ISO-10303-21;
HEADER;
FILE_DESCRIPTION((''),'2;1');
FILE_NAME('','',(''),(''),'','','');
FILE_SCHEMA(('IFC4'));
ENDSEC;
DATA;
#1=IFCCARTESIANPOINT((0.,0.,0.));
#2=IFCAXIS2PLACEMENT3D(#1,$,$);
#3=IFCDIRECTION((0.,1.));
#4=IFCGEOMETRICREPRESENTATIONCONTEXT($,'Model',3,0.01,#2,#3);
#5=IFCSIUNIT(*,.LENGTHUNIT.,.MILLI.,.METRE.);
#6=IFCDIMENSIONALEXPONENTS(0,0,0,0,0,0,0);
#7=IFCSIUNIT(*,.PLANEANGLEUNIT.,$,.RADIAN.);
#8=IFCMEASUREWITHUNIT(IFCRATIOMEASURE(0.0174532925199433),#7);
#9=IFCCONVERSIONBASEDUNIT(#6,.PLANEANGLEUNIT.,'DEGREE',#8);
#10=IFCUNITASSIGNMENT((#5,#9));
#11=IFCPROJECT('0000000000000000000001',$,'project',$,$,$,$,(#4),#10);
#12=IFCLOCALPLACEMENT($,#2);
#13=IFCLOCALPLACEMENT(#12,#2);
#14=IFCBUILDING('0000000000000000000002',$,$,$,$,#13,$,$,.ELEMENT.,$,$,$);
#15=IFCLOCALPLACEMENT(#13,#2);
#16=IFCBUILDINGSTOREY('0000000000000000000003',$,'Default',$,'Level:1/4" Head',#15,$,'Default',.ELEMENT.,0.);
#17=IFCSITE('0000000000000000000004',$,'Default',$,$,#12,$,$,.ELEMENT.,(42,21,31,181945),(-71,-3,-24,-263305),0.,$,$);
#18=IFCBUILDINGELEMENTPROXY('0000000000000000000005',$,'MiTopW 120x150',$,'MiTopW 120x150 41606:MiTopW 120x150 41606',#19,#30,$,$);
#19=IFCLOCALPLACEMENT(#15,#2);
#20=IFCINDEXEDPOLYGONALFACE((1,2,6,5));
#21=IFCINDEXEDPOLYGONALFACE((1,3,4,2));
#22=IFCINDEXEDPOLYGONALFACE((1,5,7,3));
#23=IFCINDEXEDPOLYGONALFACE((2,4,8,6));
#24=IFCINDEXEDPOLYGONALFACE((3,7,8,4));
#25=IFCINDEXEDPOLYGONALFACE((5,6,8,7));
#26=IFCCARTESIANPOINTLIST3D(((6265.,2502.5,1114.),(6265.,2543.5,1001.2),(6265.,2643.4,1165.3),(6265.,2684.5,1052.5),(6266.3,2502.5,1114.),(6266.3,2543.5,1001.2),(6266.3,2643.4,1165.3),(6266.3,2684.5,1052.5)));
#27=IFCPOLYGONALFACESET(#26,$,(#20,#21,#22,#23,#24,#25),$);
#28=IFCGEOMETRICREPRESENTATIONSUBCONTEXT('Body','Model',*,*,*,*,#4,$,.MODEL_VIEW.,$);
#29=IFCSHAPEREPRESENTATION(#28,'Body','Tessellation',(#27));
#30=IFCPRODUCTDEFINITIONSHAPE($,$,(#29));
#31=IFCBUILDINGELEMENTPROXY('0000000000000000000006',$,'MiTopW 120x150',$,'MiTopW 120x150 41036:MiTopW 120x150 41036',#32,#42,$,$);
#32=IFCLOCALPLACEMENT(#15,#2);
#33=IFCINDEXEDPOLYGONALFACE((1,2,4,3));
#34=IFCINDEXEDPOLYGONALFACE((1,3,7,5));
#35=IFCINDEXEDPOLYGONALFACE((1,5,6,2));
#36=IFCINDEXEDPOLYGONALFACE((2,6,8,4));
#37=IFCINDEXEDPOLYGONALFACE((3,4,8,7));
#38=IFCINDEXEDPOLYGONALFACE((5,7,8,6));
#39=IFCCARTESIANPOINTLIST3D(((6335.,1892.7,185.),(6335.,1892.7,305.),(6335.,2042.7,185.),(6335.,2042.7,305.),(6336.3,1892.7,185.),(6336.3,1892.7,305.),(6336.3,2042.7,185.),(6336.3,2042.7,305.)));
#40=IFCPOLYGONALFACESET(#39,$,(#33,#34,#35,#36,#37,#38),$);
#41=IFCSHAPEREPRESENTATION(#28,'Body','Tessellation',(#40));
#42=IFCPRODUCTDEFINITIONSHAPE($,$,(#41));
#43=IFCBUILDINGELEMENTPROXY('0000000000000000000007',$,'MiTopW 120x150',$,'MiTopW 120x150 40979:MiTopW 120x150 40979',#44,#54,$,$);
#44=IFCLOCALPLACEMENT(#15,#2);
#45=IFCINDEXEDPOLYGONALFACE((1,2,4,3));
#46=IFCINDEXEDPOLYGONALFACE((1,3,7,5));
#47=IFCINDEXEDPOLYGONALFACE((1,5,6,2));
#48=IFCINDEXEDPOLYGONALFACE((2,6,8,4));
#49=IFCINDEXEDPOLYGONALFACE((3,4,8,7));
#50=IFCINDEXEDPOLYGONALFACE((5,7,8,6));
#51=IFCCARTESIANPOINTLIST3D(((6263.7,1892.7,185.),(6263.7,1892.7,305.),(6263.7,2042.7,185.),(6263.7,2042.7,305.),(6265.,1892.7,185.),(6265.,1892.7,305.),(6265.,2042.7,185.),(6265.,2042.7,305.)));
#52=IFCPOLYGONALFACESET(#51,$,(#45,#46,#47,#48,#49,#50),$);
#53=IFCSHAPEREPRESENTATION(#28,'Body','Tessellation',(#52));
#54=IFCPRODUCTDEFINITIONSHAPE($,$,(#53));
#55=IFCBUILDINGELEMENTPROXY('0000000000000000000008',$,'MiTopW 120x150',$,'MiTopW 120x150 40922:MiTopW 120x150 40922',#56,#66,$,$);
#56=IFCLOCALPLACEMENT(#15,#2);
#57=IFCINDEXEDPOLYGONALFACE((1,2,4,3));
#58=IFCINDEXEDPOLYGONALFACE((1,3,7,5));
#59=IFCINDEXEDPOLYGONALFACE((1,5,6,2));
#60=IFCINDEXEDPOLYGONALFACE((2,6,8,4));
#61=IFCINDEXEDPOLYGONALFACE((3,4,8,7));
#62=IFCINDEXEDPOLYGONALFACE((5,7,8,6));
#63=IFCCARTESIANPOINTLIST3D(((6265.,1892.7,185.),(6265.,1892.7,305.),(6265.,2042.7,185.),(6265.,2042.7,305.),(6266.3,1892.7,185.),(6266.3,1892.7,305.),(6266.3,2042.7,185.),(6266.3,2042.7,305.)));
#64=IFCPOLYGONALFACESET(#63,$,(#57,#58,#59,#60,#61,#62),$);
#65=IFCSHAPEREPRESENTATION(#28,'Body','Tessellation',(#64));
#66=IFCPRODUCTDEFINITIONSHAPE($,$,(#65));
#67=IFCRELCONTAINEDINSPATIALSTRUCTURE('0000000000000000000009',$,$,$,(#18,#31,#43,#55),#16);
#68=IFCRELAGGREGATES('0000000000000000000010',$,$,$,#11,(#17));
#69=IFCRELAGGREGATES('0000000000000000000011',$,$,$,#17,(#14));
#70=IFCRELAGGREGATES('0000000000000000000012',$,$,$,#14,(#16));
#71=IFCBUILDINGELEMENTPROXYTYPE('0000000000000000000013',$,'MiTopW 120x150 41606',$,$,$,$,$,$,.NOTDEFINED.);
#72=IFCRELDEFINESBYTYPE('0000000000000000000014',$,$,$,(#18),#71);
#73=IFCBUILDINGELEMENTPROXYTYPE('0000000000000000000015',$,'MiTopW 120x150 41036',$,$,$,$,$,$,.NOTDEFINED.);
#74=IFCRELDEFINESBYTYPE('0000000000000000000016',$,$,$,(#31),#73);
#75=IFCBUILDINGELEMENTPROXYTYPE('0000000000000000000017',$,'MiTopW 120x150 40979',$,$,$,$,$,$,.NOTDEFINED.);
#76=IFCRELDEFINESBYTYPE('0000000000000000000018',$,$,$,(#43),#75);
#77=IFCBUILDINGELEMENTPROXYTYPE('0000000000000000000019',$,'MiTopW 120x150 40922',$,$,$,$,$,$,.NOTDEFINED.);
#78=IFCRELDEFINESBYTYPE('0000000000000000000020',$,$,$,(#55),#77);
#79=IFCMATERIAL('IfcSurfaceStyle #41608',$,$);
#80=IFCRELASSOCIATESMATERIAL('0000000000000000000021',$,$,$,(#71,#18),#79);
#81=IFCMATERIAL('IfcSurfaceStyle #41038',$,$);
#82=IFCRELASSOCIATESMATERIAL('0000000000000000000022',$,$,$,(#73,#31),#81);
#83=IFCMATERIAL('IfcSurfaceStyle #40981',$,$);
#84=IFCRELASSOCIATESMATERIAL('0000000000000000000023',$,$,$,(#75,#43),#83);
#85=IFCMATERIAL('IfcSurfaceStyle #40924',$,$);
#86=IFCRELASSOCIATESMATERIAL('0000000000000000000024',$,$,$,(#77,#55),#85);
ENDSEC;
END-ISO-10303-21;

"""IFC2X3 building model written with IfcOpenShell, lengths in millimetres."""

from ifc_helpers import new_model, entity, si_unit, converted_unit, direction, frame, origin, origin_2d_with_axis, place, context, subcontext, project, spatial, polyline, rectangle, outline, extrude, source, transform, mapped, material, type_object, type_shapes, element, save


model = new_model("IFC2X3")

# Units and contexts
model_context = context("Model", 3, precision=0.01, world=origin(), true_north=direction((0.0, 1.0)))
body_context = subcontext(model_context, "Body", "Model", "MODEL_VIEW")
ifc_project = project(units=[si_unit("LENGTHUNIT", "METRE", prefix="MILLI"), converted_unit("PLANEANGLEUNIT", "DEGREE", entity("IfcRatioMeasure", 0.0174532925199433), si_unit("PLANEANGLEUNIT", "RADIAN"), dimensions=[0, 0, 0, 0, 0, 0, 0])], contexts=[model_context])

# Site, building, storey
site_placement = place(None, origin())
site = spatial("IfcSite", under=ifc_project, at=site_placement, Name="Default", CompositionType="ELEMENT", RefLatitude=(42, 21, 31, 181945), RefLongitude=(-71, -3, -24, -263305), RefElevation=0.0)
building_placement = place(site_placement, origin())
building = spatial("IfcBuilding", under=site, at=building_placement, CompositionType="ELEMENT")
storey_placement = place(building_placement, origin())
storey = spatial("IfcBuildingStorey", under=building, at=storey_placement, Name="Default", ObjectType="Level:1/4\" Head", LongName="Default", CompositionType="ELEMENT", Elevation=0.0)

# Building element proxies
ifc_material_1 = material(Name="IfcSurfaceStyle #41608")
building_element_proxy_type_1 = type_object("IfcBuildingElementProxyType", Name="MiTopW 120x150 41606", PredefinedType="NOTDEFINED", material=ifc_material_1)
shared_shape_1 = source(origin(), body_context, "Body", "SweptSolid", [
    extrude(outline(polyline([(-75.0, -60.0), (75.0, -60.0), (75.0, 60.0), (-75.0, 60.0), (-75.0, -60.0)])), frame((75.0, 60.0, 0.0), z_axis=(0.0, 0.0, 1.0), x_axis=(-1.0, 0.0, 0.0)), (0.0, 0.0, 1.0), 1.3),
])
type_shapes(building_element_proxy_type_1, [shared_shape_1])
proxy_1_placement = place(building_placement, frame((6266.3, 2502.5, 1114.0), z_axis=(-1.0, 0.0, 0.0), x_axis=(0.0, 0.939693, 0.34202)))
element("IfcBuildingElementProxy", 1, at=proxy_1_placement, inside=storey, type_object=building_element_proxy_type_1, material=ifc_material_1, Name="MiTopW 120x150", ObjectType="MiTopW 120x150 41606:MiTopW 120x150 41606", context=body_context, shape_type="MappedRepresentation", body=[
    mapped(shared_shape_1, transform((0.0, 0.0, 0.0), scale=1.0)),
])
ifc_material_2 = material(Name="IfcSurfaceStyle #41038")
building_element_proxy_type_2 = type_object("IfcBuildingElementProxyType", Name="MiTopW 120x150 41036", PredefinedType="NOTDEFINED", material=ifc_material_2)
shared_shape_2 = source(origin(), body_context, "Body", "SweptSolid", [
    extrude(rectangle(XDim=150.0, YDim=120.0, at=origin_2d_with_axis()), frame((75.0, 60.0, 0.0), z_axis=(0.0, 0.0, 1.0), x_axis=(-1.0, 0.0, 0.0)), (0.0, 0.0, 1.0), 1.3),
])
type_shapes(building_element_proxy_type_2, [shared_shape_2])
proxy_2_placement = place(building_placement, frame((6336.3, 1892.7, 305.0), z_axis=(-1.0, 0.0, 0.0), x_axis=(0.0, 1.0, 0.0)))
element("IfcBuildingElementProxy", 2, at=proxy_2_placement, inside=storey, type_object=building_element_proxy_type_2, material=ifc_material_2, Name="MiTopW 120x150", ObjectType="MiTopW 120x150 41036:MiTopW 120x150 41036", context=body_context, shape_type="MappedRepresentation", body=[
    mapped(shared_shape_2, transform((0.0, 0.0, 0.0), scale=1.0)),
])
ifc_material_3 = material(Name="IfcSurfaceStyle #40981")
building_element_proxy_type_3 = type_object("IfcBuildingElementProxyType", Name="MiTopW 120x150 40979", PredefinedType="NOTDEFINED", material=ifc_material_3)
shared_shape_3 = source(origin(), body_context, "Body", "SweptSolid", [
    extrude(rectangle(XDim=150.0, YDim=120.0, at=origin_2d_with_axis()), frame((75.0, 60.0, 0.0), z_axis=(0.0, 0.0, 1.0), x_axis=(-1.0, 0.0, 0.0)), (0.0, 0.0, 1.0), 1.3),
])
type_shapes(building_element_proxy_type_3, [shared_shape_3])
proxy_3_placement = place(building_placement, frame((6265.0, 1892.7, 305.0), z_axis=(-1.0, 0.0, 0.0), x_axis=(0.0, 1.0, 0.0)))
element("IfcBuildingElementProxy", 3, at=proxy_3_placement, inside=storey, type_object=building_element_proxy_type_3, material=ifc_material_3, Name="MiTopW 120x150", ObjectType="MiTopW 120x150 40979:MiTopW 120x150 40979", context=body_context, shape_type="MappedRepresentation", body=[
    mapped(shared_shape_3, transform((0.0, 0.0, 0.0), scale=1.0)),
])
ifc_material_4 = material(Name="IfcSurfaceStyle #40924")
building_element_proxy_type_4 = type_object("IfcBuildingElementProxyType", Name="MiTopW 120x150 40922", PredefinedType="NOTDEFINED", material=ifc_material_4)
shared_shape_4 = source(origin(), body_context, "Body", "SweptSolid", [
    extrude(rectangle(XDim=150.0, YDim=120.0, at=origin_2d_with_axis()), frame((75.0, 60.0, 0.0), z_axis=(0.0, 0.0, 1.0), x_axis=(-1.0, 0.0, 0.0)), (0.0, 0.0, 1.0), 1.3),
])
type_shapes(building_element_proxy_type_4, [shared_shape_4])
proxy_4_placement = place(building_placement, frame((6266.3, 1892.7, 305.0), z_axis=(-1.0, 0.0, 0.0), x_axis=(0.0, 1.0, 0.0)))
element("IfcBuildingElementProxy", 4, at=proxy_4_placement, inside=storey, type_object=building_element_proxy_type_4, material=ifc_material_4, Name="MiTopW 120x150", ObjectType="MiTopW 120x150 40922:MiTopW 120x150 40922", context=body_context, shape_type="MappedRepresentation", body=[
    mapped(shared_shape_4, transform((0.0, 0.0, 0.0), scale=1.0)),
])

save(model, "model.ifc")
